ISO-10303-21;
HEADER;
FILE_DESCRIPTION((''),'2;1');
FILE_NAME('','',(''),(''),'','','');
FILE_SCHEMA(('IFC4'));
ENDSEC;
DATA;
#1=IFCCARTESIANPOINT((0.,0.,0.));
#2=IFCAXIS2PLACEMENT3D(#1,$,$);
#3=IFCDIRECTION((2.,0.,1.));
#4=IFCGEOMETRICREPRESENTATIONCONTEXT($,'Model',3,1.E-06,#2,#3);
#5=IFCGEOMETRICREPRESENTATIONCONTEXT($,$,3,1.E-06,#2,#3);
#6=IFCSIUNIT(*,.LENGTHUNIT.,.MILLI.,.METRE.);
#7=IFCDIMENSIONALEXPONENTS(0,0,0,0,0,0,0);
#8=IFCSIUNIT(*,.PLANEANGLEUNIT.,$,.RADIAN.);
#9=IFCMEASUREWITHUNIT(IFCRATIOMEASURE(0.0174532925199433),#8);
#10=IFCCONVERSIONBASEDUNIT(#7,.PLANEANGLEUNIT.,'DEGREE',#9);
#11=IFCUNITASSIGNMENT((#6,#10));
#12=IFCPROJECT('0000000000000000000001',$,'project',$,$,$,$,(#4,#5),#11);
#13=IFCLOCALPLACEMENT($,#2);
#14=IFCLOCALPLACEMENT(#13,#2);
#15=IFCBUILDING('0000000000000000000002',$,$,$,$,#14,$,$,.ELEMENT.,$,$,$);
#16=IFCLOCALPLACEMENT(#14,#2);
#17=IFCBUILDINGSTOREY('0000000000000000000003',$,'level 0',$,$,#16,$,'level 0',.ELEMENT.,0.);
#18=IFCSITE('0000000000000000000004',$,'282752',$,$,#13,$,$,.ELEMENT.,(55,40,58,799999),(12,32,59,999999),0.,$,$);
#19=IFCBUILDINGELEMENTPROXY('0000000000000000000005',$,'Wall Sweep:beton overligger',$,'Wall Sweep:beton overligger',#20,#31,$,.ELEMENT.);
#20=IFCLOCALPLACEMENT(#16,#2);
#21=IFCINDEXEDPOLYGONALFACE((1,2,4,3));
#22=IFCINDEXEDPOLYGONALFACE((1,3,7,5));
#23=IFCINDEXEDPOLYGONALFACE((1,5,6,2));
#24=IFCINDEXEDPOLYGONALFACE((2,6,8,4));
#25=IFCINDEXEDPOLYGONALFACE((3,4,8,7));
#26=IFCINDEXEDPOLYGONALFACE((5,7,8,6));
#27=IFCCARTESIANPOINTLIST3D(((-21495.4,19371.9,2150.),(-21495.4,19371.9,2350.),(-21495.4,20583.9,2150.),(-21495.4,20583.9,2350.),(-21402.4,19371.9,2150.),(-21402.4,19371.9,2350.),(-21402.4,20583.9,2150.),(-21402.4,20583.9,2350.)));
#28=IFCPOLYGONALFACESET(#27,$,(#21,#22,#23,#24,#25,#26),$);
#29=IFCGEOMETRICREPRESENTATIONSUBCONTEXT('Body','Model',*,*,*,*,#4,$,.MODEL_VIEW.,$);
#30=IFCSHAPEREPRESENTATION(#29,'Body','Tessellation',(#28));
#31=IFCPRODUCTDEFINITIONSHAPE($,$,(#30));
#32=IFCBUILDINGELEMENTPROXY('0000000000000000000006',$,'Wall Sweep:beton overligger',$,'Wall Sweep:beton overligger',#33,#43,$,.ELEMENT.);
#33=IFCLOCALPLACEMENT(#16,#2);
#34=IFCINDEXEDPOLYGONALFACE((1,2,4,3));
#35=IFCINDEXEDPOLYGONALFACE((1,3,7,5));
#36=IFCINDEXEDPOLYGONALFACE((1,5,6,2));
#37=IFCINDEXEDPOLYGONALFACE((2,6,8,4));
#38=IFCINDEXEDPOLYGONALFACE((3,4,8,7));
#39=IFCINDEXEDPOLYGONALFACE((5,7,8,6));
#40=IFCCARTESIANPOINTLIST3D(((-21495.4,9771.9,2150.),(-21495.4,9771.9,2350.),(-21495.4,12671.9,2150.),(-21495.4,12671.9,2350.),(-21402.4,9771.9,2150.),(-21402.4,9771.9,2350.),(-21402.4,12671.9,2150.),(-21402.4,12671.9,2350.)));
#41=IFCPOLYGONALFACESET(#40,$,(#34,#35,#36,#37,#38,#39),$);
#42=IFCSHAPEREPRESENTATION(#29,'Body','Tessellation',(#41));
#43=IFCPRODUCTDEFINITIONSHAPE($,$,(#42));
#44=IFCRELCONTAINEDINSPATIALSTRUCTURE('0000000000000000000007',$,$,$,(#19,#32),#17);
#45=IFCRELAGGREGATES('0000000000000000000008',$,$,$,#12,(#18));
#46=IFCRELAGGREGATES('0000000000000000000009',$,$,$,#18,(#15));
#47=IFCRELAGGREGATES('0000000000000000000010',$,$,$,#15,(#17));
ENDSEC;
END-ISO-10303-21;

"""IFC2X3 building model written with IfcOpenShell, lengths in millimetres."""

from ifc_helpers import new_model, entity, si_unit, converted_unit, direction, frame, frame_2d, origin, place, context, subcontext, project, spatial, rectangle, extrude, element, save


model = new_model("IFC2X3")

# Units and contexts
model_context = context("Model", 3, precision=1e-06, world=origin(), true_north=direction((2.0, 0.0, 1.0)))
context_of_model = context(None, 3, precision=1e-06, world=origin(), true_north=direction((2.0, 0.0, 1.0)))
body_context = subcontext(model_context, "Body", "Model", "MODEL_VIEW")
ifc_project = project(units=[si_unit("LENGTHUNIT", "METRE", prefix="MILLI"), converted_unit("PLANEANGLEUNIT", "DEGREE", entity("IfcRatioMeasure", 0.0174532925199433), si_unit("PLANEANGLEUNIT", "RADIAN"), dimensions=[0, 0, 0, 0, 0, 0, 0])], contexts=[model_context, context_of_model])

# Site, building, storey
site_placement = place(None, origin())
site = spatial("IfcSite", under=ifc_project, at=site_placement, Name="282752", CompositionType="ELEMENT", RefLatitude=(55, 40, 58, 799999), RefLongitude=(12, 32, 59, 999999), RefElevation=0.0)
building_placement = place(site_placement, origin())
building = spatial("IfcBuilding", under=site, at=building_placement, CompositionType="ELEMENT")
storey_placement = place(building_placement, origin())
storey = spatial("IfcBuildingStorey", under=building, at=storey_placement, Name="level 0", LongName="level 0", CompositionType="ELEMENT", Elevation=0.0)

# Building element proxies
proxy_1_placement = place(storey_placement, origin())
element("IfcBuildingElementProxy", 1, at=proxy_1_placement, inside=storey, Name="Wall Sweep:beton overligger", ObjectType="Wall Sweep:beton overligger", CompositionType="ELEMENT", context=body_context, shape_type="SweptSolid", body=[
    extrude(rectangle(XDim=1212.0, YDim=93.0, at=frame_2d((0.0, 0.0), x_axis=(1.0, 0.0))), frame((-21448.9, 19977.9, 2150.0), z_axis=(0.0, 0.0, 1.0), x_axis=(0.0, 1.0, 0.0)), (0.0, 0.0, 1.0), 200.0),
])
proxy_2_placement = place(storey_placement, origin())
element("IfcBuildingElementProxy", 2, at=proxy_2_placement, inside=storey, Name="Wall Sweep:beton overligger", ObjectType="Wall Sweep:beton overligger", CompositionType="ELEMENT", context=body_context, shape_type="SweptSolid", body=[
    extrude(rectangle(XDim=2900.0, YDim=93.0, at=frame_2d((0.0, 0.0), x_axis=(1.0, 0.0))), frame((-21448.9, 11221.9, 2150.0), z_axis=(0.0, 0.0, 1.0), x_axis=(0.0, 1.0, 0.0)), (0.0, 0.0, 1.0), 200.0),
])

save(model, "model.ifc")
